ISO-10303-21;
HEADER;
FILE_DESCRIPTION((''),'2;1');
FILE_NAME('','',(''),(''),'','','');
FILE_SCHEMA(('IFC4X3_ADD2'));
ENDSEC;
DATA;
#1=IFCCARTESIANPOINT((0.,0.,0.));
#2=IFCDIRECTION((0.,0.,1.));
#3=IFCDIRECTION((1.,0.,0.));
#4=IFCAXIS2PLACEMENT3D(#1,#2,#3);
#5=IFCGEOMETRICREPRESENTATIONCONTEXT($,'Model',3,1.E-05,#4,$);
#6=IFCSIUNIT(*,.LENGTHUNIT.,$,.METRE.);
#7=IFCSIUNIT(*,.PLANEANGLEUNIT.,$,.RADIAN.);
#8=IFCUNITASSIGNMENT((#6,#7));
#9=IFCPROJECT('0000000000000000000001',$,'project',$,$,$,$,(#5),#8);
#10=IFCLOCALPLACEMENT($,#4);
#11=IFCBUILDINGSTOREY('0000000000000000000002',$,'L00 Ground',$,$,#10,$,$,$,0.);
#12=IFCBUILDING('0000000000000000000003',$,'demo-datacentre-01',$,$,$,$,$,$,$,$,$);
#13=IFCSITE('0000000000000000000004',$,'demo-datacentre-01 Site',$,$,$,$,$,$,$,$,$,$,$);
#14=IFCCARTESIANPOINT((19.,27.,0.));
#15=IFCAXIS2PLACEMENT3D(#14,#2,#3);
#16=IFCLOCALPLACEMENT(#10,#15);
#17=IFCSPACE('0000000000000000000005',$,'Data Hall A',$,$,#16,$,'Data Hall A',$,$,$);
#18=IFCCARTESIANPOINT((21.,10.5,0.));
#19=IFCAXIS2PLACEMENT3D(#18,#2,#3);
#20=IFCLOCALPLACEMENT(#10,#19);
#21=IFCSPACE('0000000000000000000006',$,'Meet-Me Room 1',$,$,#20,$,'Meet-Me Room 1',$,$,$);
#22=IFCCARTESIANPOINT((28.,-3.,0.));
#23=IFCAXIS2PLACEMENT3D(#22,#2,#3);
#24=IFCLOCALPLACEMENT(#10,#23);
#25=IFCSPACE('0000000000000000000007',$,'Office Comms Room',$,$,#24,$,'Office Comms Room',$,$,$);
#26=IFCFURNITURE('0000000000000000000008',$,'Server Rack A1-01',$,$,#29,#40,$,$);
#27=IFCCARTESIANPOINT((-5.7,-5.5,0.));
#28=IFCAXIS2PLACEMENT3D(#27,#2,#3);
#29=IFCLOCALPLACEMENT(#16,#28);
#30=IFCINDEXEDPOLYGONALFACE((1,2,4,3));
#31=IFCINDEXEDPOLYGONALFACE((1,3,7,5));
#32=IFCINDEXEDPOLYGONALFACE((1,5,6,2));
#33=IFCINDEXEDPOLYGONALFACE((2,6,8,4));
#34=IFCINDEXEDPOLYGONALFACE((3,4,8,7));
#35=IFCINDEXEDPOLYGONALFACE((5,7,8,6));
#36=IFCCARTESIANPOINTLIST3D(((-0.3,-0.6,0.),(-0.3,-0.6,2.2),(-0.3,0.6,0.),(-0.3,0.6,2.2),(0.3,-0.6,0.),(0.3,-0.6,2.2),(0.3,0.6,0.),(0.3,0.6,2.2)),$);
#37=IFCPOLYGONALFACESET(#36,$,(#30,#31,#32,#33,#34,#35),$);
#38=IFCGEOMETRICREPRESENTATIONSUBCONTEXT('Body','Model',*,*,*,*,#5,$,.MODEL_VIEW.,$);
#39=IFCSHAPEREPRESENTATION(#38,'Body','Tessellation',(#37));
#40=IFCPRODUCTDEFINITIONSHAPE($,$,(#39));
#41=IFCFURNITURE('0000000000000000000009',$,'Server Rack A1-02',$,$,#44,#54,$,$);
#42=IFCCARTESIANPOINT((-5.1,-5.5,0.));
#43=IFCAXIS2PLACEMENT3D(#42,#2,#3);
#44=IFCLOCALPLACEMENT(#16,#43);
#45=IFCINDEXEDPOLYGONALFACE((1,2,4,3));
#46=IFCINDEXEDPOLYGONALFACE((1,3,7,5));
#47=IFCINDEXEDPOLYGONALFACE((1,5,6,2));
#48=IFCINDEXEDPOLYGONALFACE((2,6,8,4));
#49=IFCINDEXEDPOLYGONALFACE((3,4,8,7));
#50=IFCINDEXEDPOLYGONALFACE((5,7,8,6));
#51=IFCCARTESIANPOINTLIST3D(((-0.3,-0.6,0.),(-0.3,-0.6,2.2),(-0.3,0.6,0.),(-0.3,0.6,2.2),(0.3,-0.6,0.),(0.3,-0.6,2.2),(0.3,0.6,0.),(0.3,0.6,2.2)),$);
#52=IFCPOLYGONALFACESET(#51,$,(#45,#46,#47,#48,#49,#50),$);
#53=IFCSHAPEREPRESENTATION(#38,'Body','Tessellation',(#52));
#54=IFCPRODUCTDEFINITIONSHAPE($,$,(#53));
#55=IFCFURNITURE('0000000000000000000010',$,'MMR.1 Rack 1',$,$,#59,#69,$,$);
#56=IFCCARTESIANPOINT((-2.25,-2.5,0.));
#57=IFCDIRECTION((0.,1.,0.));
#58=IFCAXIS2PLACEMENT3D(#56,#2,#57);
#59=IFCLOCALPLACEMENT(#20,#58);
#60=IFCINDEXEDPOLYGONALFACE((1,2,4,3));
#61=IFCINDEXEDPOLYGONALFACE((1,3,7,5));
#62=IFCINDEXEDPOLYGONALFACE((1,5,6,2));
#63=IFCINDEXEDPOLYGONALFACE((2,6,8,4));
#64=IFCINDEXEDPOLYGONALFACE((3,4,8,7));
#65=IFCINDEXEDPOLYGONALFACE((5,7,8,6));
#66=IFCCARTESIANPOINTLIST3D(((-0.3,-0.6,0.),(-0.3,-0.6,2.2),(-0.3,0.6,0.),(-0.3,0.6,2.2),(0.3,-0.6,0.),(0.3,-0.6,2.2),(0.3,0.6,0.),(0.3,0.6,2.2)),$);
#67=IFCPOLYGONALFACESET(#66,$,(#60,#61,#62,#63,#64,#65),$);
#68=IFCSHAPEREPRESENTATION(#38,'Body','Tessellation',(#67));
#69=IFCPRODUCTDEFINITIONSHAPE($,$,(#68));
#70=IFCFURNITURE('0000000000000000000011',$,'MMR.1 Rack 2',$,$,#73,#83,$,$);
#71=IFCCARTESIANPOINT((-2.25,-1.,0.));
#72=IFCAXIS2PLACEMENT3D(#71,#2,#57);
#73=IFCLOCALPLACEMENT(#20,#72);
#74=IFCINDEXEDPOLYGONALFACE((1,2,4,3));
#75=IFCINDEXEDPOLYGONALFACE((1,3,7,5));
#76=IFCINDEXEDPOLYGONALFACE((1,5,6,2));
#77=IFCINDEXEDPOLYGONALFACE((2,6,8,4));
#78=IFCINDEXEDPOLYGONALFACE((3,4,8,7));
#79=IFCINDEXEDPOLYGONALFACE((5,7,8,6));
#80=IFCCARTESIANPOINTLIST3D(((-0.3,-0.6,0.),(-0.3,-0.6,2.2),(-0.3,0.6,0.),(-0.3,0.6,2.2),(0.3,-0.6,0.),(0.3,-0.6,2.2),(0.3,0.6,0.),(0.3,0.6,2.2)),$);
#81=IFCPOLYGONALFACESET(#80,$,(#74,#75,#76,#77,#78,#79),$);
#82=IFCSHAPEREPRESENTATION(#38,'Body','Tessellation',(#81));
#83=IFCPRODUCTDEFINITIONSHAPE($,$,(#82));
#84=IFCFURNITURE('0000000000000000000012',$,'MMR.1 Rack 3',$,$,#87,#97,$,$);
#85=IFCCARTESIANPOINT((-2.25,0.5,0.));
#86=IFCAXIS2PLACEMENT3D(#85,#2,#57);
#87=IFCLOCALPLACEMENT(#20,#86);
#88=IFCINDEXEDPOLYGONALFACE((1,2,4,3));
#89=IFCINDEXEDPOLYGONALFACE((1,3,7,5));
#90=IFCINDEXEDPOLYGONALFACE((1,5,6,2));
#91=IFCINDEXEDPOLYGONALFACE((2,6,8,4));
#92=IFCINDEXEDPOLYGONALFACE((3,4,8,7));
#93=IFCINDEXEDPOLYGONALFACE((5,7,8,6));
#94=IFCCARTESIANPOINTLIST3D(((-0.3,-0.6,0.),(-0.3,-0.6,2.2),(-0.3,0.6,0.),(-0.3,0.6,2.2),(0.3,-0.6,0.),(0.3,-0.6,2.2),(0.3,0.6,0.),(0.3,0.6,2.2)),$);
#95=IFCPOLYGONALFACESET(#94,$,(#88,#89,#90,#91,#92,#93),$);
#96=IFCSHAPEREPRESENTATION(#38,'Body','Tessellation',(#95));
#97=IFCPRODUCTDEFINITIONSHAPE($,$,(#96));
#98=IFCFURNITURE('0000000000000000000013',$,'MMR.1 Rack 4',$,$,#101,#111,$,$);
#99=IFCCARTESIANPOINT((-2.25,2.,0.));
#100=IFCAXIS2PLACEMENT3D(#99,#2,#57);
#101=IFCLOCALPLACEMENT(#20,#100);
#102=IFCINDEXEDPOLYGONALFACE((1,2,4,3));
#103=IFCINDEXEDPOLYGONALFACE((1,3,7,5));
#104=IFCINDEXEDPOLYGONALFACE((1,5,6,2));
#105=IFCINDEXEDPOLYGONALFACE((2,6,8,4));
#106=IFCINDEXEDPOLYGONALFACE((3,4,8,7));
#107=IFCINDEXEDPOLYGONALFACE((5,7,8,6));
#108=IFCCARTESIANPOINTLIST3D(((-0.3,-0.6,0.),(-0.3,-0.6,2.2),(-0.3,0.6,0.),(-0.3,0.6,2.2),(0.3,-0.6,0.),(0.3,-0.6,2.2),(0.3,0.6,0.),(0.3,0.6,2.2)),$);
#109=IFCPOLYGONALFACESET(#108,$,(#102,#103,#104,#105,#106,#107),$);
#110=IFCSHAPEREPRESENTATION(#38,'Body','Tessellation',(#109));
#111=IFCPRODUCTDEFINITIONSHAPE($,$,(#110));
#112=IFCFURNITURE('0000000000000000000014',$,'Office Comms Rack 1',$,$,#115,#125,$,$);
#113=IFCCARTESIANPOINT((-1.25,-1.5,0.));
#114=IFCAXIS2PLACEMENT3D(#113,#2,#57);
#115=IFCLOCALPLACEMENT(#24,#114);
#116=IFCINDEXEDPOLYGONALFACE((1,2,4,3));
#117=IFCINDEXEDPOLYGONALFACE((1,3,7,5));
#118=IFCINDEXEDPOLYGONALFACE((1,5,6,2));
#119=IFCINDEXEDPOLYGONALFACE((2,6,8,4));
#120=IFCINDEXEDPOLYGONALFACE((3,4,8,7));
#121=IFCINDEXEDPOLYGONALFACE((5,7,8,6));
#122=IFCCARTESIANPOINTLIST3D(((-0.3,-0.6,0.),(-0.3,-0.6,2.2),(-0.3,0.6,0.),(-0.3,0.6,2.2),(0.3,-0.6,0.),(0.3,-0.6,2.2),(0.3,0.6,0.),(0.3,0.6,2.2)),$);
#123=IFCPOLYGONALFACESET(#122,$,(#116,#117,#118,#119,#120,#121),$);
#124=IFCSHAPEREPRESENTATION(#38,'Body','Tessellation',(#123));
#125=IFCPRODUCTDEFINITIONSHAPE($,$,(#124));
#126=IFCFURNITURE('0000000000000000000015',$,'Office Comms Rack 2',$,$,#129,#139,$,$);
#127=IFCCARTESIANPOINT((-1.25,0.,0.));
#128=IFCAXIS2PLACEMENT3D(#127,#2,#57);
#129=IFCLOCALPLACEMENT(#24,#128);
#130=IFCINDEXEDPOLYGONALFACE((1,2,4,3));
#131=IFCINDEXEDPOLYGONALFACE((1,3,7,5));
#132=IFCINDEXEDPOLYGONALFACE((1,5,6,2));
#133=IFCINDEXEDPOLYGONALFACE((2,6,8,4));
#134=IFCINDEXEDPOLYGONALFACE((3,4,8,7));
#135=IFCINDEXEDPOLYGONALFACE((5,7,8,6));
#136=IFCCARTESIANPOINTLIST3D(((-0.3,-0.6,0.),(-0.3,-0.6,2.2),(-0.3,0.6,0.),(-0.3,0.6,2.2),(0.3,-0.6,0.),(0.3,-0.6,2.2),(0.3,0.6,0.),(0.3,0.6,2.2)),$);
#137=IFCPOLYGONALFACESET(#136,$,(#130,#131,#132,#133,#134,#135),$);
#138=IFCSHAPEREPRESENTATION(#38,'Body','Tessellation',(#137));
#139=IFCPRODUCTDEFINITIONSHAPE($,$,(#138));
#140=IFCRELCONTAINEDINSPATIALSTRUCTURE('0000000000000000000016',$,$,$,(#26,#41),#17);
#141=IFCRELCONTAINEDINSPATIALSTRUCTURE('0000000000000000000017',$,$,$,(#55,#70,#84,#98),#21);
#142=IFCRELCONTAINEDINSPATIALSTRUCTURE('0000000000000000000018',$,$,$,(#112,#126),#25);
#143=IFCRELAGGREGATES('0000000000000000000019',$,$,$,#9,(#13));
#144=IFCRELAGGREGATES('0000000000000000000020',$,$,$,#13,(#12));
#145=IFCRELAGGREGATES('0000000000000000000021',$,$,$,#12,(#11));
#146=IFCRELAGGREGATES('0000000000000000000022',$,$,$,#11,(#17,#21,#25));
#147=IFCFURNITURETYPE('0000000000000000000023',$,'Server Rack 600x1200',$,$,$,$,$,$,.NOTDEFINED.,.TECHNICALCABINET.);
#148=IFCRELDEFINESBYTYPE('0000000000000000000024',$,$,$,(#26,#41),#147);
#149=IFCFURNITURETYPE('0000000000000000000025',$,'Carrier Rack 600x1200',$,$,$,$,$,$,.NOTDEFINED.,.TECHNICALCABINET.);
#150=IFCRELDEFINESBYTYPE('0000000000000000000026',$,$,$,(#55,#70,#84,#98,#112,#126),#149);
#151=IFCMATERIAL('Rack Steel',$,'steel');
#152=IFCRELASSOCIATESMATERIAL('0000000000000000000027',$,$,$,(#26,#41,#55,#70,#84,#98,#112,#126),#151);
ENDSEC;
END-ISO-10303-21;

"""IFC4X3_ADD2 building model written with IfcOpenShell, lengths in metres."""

from ifc_helpers import new_model, si_unit, frame, origin_with_axes, place, context, subcontext, project, spatial, rectangle, extrude, material, type_object, element, save


model = new_model("IFC4X3_ADD2")

# Units and contexts
model_context = context("Model", 3, precision=1e-05, world=origin_with_axes())
body_context = subcontext(model_context, "Body", "Model", "MODEL_VIEW")
ifc_project = project(units=[si_unit("LENGTHUNIT", "METRE"), si_unit("PLANEANGLEUNIT", "RADIAN")], contexts=[model_context])

# Site, building, storey
site = spatial("IfcSite", under=ifc_project, Name="demo-datacentre-01 Site")
building = spatial("IfcBuilding", under=site, Name="demo-datacentre-01")
storey_placement = place(None, origin_with_axes())
storey = spatial("IfcBuildingStorey", under=building, at=storey_placement, Name="L00 Ground", Elevation=0.0)

# Shared definitions
space_1_placement = place(storey_placement, frame((19.0, 27.0, 0.0), z_axis=(0.0, 0.0, 1.0), x_axis=(1.0, 0.0, 0.0)))
space_1 = spatial("IfcSpace", under=storey, at=space_1_placement, Name="Data Hall A", LongName="Data Hall A")

# Furniture
ifc_material_1 = material(Name="Rack Steel", Category="steel")
furniture_type_1 = type_object("IfcFurnitureType", Name="Server Rack 600x1200", AssemblyPlace="NOTDEFINED", PredefinedType="TECHNICALCABINET")
for number, where, z_axis, x_axis, name in (
    (1, (-5.7, -5.5, 0.0), (0.0, 0.0, 1.0), (1.0, 0.0, 0.0), "Server Rack A1-01"),
    (2, (-5.1, -5.5, 0.0), (0.0, 0.0, 1.0), (1.0, 0.0, 0.0), "Server Rack A1-02"),
):
    element("IfcFurniture", number, at=place(space_1_placement, frame(where, z_axis=z_axis, x_axis=x_axis)), inside=space_1, type_object=furniture_type_1, material=ifc_material_1, Name=name, context=body_context, shape_type="SweptSolid", body=[
        extrude(rectangle(XDim=0.6, YDim=1.2), origin_with_axes(), (0.0, 0.0, 1.0), 2.2),
    ])

# Shared definitions
space_2_placement = place(storey_placement, frame((21.0, 10.5, 0.0), z_axis=(0.0, 0.0, 1.0), x_axis=(1.0, 0.0, 0.0)))
space_2 = spatial("IfcSpace", under=storey, at=space_2_placement, Name="Meet-Me Room 1", LongName="Meet-Me Room 1")

# Furniture
furniture_type_2 = type_object("IfcFurnitureType", Name="Carrier Rack 600x1200", AssemblyPlace="NOTDEFINED", PredefinedType="TECHNICALCABINET")
for number, where, z_axis, x_axis, name in (
    (3, (-2.25, -2.5, 0.0), (0.0, 0.0, 1.0), (0.0, 1.0, 0.0), "MMR.1 Rack 1"),
    (4, (-2.25, -1.0, 0.0), (0.0, 0.0, 1.0), (0.0, 1.0, 0.0), "MMR.1 Rack 2"),
    (5, (-2.25, 0.5, 0.0), (0.0, 0.0, 1.0), (0.0, 1.0, 0.0), "MMR.1 Rack 3"),
    (6, (-2.25, 2.0, 0.0), (0.0, 0.0, 1.0), (0.0, 1.0, 0.0), "MMR.1 Rack 4"),
):
    element("IfcFurniture", number, at=place(space_2_placement, frame(where, z_axis=z_axis, x_axis=x_axis)), inside=space_2, type_object=furniture_type_2, material=ifc_material_1, Name=name, context=body_context, shape_type="SweptSolid", body=[
        extrude(rectangle(XDim=0.6, YDim=1.2), origin_with_axes(), (0.0, 0.0, 1.0), 2.2),
    ])

# Shared definitions
space_3_placement = place(storey_placement, frame((28.0, -3.0, 0.0), z_axis=(0.0, 0.0, 1.0), x_axis=(1.0, 0.0, 0.0)))
space_3 = spatial("IfcSpace", under=storey, at=space_3_placement, Name="Office Comms Room", LongName="Office Comms Room")

# Furniture
for number, where, z_axis, x_axis, name in (
    (7, (-1.25, -1.5, 0.0), (0.0, 0.0, 1.0), (0.0, 1.0, 0.0), "Office Comms Rack 1"),
    (8, (-1.25, 0.0, 0.0), (0.0, 0.0, 1.0), (0.0, 1.0, 0.0), "Office Comms Rack 2"),
):
    element("IfcFurniture", number, at=place(space_3_placement, frame(where, z_axis=z_axis, x_axis=x_axis)), inside=space_3, type_object=furniture_type_2, material=ifc_material_1, Name=name, context=body_context, shape_type="SweptSolid", body=[
        extrude(rectangle(XDim=0.6, YDim=1.2), origin_with_axes(), (0.0, 0.0, 1.0), 2.2),
    ])

save(model, "model.ifc")
